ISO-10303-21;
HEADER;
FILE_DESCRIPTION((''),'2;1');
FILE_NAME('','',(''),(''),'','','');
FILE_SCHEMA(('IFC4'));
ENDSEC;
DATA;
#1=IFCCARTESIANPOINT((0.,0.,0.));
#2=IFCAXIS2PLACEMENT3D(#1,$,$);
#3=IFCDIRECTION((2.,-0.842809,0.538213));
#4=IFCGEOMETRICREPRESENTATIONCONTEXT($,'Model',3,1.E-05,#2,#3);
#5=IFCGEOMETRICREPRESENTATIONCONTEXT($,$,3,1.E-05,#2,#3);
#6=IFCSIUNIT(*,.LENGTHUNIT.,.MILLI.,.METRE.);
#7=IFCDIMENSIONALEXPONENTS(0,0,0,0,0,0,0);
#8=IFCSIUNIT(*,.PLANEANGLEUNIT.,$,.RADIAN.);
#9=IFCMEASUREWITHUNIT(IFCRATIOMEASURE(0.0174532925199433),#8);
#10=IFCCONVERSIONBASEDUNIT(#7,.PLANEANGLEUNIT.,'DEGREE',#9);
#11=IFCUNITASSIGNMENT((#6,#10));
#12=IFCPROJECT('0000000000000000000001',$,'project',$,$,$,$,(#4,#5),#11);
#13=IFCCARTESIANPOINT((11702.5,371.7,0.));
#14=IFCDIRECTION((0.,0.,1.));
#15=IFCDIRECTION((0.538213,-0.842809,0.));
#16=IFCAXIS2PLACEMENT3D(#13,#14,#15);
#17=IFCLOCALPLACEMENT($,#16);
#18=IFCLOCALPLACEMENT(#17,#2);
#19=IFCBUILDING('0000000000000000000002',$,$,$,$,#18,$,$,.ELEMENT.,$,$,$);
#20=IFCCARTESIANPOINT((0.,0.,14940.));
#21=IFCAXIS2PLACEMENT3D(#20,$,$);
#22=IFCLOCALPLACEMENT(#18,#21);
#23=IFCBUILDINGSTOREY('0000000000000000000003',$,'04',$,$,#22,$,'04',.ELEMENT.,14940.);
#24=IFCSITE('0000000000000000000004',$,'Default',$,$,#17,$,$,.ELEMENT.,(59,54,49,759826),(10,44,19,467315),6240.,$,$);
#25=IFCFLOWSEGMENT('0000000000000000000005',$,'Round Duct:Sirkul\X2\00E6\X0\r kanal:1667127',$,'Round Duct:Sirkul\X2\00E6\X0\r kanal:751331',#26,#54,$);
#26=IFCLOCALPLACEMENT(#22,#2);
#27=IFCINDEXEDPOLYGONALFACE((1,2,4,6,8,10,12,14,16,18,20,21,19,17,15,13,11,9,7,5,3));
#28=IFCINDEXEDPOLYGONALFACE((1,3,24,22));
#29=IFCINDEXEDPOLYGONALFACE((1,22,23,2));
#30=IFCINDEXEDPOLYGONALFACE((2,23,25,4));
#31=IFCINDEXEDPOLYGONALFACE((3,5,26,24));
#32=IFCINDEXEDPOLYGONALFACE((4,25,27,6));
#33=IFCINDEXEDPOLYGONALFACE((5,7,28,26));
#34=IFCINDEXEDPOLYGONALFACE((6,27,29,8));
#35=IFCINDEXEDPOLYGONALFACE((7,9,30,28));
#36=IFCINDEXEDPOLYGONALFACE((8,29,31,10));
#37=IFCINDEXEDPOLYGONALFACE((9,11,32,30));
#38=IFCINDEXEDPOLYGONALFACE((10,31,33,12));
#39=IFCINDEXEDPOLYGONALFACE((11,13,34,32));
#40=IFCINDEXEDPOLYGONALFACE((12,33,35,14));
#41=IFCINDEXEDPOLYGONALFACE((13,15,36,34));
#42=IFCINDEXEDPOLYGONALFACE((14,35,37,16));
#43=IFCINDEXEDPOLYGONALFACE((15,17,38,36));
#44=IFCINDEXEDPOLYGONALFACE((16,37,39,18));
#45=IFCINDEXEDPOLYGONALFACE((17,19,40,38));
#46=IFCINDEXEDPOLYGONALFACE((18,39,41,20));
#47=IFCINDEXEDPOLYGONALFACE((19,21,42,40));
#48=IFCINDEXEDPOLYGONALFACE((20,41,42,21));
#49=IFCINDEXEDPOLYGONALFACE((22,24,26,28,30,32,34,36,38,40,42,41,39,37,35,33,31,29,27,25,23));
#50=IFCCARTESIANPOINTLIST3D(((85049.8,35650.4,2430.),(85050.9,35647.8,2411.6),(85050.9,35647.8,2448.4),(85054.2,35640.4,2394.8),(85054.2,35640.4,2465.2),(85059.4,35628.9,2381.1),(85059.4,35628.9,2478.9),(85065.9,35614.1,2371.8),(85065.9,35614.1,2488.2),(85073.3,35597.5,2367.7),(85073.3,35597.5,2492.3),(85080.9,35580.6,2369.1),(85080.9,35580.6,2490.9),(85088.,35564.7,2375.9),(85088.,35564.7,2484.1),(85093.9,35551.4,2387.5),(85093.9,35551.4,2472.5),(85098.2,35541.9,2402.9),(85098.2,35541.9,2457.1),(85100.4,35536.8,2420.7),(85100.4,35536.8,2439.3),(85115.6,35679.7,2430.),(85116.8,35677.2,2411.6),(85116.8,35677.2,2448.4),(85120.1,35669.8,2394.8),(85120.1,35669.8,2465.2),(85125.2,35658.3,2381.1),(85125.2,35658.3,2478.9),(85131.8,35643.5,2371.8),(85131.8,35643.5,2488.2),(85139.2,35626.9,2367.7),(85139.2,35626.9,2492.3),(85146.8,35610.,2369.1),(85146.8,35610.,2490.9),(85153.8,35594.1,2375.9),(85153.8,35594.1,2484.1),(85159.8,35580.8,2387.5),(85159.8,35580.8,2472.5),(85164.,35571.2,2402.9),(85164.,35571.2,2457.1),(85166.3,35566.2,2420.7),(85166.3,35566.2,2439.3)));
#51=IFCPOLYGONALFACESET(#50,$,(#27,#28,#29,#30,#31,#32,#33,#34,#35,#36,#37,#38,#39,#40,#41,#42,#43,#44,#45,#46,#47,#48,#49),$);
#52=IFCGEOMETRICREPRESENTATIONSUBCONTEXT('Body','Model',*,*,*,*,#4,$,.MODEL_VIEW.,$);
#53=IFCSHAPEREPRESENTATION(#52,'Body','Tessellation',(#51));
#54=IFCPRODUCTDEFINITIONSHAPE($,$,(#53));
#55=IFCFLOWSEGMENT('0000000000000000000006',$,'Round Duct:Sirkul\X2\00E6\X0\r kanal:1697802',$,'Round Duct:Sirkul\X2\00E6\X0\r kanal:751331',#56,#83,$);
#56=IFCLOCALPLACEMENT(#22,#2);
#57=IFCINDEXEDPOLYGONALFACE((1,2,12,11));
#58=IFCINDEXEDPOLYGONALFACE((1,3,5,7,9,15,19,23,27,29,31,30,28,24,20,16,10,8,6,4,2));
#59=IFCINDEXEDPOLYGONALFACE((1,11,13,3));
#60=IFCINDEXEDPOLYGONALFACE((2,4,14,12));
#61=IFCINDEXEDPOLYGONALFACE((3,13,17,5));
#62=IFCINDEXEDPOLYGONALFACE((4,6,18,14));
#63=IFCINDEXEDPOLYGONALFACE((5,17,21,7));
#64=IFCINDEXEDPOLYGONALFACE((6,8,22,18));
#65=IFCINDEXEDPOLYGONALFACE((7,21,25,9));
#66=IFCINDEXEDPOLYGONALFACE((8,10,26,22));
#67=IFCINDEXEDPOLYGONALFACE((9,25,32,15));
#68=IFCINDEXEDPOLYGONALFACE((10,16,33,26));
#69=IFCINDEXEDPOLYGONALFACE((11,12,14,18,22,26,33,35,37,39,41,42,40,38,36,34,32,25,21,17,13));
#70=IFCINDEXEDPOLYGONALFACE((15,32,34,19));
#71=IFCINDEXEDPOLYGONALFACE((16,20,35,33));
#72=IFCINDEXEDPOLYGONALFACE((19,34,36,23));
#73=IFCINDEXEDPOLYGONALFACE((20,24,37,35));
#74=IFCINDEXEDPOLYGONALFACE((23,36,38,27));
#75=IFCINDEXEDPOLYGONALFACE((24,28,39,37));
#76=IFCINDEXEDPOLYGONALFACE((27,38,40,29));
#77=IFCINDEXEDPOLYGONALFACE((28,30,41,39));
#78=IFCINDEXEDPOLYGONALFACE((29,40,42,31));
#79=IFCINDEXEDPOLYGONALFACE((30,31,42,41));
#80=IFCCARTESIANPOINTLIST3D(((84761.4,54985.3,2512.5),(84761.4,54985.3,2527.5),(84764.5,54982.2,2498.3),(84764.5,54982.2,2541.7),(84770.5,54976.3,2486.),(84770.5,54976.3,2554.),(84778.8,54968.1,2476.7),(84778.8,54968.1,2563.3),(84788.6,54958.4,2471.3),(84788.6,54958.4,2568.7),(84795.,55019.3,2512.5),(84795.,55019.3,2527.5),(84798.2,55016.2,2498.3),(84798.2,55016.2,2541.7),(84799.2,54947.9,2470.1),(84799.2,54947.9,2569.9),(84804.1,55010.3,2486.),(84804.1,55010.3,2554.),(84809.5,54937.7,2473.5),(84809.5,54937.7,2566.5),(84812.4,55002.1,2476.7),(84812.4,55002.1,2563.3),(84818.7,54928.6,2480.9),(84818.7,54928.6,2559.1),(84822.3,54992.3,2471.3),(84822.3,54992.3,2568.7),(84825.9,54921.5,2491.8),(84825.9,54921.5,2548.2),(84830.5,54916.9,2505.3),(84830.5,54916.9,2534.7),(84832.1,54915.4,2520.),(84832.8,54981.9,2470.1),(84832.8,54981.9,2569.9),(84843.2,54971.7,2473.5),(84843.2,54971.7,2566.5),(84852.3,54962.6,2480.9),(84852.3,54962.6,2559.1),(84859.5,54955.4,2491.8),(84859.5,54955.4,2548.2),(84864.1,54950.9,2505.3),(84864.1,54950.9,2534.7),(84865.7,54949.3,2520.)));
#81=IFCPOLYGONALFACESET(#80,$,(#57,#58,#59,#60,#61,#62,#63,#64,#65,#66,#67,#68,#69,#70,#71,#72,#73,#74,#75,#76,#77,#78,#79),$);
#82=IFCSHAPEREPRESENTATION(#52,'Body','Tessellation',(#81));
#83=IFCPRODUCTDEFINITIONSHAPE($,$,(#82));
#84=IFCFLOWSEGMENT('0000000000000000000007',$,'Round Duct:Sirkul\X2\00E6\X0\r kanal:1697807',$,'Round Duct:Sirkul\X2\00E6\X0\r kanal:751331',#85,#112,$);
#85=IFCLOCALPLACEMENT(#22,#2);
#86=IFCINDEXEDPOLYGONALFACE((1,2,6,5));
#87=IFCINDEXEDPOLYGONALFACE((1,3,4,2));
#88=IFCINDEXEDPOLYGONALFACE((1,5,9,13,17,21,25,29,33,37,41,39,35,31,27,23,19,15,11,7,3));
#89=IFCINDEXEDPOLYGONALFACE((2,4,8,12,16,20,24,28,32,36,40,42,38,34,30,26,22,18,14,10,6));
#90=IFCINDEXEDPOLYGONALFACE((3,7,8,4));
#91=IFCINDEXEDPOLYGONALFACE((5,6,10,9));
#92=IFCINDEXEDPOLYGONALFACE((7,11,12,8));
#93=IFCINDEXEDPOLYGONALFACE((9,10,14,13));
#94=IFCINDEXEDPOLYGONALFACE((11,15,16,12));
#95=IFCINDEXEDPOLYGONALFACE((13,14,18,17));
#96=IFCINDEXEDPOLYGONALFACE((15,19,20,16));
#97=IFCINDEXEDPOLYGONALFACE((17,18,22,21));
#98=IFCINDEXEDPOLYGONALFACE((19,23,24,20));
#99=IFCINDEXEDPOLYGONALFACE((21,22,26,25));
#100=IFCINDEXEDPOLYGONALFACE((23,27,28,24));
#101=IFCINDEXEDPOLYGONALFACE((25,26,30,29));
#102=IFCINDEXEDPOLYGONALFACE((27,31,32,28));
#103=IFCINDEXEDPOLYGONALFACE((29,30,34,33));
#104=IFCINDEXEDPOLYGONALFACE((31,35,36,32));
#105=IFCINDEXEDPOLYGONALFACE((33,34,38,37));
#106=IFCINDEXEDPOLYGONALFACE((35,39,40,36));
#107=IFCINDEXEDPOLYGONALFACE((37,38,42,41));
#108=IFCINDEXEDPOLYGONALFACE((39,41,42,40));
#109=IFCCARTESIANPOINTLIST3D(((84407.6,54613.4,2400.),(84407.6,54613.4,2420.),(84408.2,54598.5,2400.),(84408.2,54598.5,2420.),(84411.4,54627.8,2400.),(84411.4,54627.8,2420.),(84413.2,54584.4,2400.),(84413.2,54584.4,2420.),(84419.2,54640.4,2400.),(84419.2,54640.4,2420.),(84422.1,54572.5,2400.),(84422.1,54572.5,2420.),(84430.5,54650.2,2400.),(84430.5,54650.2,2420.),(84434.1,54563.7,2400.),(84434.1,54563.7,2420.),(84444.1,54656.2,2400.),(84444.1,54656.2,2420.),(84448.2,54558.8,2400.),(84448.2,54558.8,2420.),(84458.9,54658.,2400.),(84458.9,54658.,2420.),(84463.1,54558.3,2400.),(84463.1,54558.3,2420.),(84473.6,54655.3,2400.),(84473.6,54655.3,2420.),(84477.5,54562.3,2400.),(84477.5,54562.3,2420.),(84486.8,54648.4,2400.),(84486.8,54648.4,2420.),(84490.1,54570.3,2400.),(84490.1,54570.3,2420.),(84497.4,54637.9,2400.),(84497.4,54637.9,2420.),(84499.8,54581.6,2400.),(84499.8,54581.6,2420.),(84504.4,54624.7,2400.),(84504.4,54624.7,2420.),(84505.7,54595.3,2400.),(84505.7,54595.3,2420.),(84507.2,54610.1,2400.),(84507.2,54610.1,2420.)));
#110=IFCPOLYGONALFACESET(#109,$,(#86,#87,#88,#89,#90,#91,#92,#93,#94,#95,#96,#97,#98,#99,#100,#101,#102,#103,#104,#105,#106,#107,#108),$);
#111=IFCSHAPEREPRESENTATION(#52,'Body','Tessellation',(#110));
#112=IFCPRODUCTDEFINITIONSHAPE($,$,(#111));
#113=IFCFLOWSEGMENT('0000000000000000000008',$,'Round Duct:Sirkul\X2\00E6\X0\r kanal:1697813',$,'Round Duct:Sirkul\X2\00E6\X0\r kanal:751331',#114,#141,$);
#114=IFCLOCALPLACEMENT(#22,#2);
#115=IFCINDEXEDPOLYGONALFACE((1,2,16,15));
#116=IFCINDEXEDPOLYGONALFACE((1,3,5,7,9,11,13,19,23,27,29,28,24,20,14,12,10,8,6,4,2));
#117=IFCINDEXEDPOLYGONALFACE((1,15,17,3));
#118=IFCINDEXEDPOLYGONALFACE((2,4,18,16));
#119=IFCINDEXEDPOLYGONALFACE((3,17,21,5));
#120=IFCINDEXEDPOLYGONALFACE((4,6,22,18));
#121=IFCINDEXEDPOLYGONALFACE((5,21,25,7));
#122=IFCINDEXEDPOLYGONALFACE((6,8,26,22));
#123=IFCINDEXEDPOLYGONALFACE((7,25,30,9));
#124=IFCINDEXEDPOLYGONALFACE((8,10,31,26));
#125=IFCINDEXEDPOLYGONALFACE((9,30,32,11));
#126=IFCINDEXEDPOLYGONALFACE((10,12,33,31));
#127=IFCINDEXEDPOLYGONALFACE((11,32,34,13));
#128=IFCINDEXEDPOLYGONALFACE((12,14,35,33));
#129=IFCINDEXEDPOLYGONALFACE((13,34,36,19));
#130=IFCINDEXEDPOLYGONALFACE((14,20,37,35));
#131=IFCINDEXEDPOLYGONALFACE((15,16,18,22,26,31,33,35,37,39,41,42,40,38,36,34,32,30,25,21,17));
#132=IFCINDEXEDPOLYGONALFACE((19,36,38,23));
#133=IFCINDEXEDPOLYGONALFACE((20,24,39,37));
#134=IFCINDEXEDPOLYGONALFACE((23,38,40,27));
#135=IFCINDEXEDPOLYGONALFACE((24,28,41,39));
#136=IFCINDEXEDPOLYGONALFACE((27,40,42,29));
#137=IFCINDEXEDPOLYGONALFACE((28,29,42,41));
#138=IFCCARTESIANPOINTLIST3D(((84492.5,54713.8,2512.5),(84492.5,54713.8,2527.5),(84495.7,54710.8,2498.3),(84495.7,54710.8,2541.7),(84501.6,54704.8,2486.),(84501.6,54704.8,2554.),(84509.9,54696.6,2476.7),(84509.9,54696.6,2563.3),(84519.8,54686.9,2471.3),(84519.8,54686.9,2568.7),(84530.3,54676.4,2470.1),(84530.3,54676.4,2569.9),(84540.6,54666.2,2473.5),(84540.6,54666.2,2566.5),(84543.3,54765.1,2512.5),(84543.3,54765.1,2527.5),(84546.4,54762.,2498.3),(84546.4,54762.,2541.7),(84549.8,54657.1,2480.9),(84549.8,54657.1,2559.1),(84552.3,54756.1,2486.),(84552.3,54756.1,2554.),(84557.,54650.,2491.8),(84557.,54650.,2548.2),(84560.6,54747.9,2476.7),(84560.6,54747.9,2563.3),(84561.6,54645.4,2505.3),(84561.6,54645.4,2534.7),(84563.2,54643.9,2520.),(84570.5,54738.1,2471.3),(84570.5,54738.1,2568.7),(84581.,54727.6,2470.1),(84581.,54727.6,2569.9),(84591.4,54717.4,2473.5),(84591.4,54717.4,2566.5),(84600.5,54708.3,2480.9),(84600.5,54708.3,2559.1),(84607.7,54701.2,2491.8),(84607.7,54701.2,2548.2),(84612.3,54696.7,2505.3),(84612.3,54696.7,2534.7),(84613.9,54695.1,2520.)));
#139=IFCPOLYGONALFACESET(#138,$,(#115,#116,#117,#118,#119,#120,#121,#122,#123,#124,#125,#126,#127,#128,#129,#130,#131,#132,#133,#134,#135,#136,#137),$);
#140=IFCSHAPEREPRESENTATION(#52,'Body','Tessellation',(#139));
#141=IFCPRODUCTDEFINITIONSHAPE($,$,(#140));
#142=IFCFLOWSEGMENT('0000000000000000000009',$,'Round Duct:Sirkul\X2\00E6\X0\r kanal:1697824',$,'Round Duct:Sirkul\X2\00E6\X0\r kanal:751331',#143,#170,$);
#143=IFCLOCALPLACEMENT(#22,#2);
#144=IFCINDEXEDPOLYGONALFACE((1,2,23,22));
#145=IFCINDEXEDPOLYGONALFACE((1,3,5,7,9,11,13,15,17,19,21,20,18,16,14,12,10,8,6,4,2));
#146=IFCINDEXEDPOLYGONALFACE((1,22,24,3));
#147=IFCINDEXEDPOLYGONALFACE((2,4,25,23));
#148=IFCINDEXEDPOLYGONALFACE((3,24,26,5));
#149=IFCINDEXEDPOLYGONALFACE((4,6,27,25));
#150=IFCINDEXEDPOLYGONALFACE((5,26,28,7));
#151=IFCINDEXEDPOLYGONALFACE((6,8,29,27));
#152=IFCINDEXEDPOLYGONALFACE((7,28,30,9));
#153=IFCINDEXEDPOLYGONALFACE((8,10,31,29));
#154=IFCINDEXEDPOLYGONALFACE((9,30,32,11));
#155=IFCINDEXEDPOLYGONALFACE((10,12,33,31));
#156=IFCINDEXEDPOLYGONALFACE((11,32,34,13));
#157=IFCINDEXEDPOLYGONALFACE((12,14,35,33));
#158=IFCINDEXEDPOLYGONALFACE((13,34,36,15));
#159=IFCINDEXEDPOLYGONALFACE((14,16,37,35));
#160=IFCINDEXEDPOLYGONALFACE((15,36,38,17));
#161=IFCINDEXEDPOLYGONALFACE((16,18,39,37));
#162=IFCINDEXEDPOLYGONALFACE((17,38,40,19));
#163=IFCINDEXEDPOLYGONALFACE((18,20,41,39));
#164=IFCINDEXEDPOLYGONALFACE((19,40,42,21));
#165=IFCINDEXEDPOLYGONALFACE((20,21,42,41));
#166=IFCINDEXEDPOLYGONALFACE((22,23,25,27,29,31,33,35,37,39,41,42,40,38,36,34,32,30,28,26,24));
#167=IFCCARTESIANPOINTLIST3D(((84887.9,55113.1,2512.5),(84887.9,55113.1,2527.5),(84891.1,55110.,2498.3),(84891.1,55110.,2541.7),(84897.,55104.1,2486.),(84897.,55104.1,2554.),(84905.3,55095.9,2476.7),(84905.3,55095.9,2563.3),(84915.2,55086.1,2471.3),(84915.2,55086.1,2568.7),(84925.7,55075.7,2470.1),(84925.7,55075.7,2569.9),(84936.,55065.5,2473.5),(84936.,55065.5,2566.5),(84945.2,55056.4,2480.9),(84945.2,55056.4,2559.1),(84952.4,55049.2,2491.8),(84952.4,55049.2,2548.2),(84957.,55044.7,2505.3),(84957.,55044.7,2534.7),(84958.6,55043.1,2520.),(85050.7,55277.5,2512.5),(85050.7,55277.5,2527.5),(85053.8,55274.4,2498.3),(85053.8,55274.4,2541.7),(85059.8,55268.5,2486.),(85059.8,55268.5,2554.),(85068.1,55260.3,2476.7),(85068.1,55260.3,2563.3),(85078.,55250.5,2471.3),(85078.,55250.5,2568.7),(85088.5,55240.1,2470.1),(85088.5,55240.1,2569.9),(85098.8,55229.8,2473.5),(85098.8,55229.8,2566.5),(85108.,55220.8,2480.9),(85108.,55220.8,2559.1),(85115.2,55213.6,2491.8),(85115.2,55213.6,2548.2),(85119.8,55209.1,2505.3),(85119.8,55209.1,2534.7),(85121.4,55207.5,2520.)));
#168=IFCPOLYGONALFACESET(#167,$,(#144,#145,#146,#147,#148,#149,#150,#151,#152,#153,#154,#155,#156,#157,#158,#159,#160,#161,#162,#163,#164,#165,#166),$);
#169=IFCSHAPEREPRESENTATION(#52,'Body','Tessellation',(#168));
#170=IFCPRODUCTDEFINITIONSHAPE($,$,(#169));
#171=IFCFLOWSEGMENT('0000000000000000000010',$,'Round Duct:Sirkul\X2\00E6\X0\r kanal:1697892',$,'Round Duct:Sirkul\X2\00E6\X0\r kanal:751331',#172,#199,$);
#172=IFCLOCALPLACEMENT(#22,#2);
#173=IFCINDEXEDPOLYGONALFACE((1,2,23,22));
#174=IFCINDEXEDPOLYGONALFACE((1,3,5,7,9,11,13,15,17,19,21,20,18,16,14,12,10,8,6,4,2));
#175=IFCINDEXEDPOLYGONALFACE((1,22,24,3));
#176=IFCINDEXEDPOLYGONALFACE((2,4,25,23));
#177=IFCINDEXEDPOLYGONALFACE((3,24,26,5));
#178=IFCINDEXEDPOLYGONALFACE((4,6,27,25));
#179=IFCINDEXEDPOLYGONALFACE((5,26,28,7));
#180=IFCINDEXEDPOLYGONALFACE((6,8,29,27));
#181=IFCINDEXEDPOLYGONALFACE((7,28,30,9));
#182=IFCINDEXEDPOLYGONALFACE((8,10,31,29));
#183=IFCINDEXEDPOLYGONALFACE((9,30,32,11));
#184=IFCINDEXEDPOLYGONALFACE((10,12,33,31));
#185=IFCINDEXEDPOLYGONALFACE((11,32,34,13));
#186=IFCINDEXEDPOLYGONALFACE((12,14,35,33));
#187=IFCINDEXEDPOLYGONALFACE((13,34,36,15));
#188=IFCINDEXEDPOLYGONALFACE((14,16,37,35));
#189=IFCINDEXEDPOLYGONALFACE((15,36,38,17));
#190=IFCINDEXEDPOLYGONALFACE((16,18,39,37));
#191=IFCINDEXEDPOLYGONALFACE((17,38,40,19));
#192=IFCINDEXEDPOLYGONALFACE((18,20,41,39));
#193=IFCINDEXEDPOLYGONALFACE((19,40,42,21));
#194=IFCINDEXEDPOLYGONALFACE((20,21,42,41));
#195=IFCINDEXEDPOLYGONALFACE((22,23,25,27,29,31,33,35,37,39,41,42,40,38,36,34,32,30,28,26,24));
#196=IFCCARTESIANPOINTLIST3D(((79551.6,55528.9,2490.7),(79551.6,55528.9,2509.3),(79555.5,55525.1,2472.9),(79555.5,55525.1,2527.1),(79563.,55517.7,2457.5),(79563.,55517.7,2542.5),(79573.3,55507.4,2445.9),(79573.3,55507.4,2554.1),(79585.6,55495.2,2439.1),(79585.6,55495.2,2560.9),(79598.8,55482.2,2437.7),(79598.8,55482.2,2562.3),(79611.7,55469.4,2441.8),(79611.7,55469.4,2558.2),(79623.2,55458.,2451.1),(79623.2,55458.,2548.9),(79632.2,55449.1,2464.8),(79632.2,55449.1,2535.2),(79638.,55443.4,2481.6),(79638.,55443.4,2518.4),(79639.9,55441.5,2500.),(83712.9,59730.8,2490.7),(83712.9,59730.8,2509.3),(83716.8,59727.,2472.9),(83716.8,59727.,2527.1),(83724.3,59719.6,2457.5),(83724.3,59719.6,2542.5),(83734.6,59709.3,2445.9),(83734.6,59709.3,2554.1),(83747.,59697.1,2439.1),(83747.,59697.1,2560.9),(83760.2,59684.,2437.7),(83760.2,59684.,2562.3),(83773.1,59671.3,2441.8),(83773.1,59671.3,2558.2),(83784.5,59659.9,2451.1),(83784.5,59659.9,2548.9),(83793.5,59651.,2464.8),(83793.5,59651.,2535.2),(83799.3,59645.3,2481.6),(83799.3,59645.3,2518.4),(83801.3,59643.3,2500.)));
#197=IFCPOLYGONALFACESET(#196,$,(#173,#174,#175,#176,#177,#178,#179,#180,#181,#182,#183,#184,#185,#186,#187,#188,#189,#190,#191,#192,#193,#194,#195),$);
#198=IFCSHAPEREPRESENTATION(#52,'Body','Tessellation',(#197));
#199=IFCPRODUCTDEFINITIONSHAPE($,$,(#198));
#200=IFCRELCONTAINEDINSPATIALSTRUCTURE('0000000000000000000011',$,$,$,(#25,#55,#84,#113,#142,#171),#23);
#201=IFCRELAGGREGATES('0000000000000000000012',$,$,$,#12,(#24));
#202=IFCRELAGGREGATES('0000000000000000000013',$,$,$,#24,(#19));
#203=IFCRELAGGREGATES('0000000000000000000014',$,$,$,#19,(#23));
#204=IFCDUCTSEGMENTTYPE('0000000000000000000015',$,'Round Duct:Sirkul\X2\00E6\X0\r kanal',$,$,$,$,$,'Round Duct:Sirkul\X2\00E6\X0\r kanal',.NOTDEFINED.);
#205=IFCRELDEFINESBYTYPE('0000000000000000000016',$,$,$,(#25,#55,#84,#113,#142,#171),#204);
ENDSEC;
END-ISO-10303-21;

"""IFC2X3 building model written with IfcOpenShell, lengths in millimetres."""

from ifc_helpers import new_model, entity, si_unit, converted_unit, direction, frame, frame_2d, origin, origin_2d_with_axis, place, context, subcontext, project, spatial, circle, extrude, type_object, element, save


model = new_model("IFC2X3")

# Units and contexts
model_context = context("Model", 3, precision=1e-05, world=origin(), true_north=direction((2.0, -0.842809, 0.538213)))
context_of_model = context(None, 3, precision=1e-05, world=origin(), true_north=direction((2.0, -0.842809, 0.538213)))
body_context = subcontext(model_context, "Body", "Model", "MODEL_VIEW")
ifc_project = project(units=[si_unit("LENGTHUNIT", "METRE", prefix="MILLI"), converted_unit("PLANEANGLEUNIT", "DEGREE", entity("IfcRatioMeasure", 0.0174532925199433), si_unit("PLANEANGLEUNIT", "RADIAN"), dimensions=[0, 0, 0, 0, 0, 0, 0])], contexts=[model_context, context_of_model])

# Site, building, storey
site_placement = place(None, frame((11702.5, 371.7, 0.0), z_axis=(0.0, 0.0, 1.0), x_axis=(0.538213, -0.842809, 0.0)))
site = spatial("IfcSite", under=ifc_project, at=site_placement, Name="Default", CompositionType="ELEMENT", RefLatitude=(59, 54, 49, 759826), RefLongitude=(10, 44, 19, 467315), RefElevation=6240.0)
building_placement = place(site_placement, origin())
building = spatial("IfcBuilding", under=site, at=building_placement, CompositionType="ELEMENT")
storey_placement = place(building_placement, frame((0.0, 0.0, 14940.0)))
storey = spatial("IfcBuildingStorey", under=building, at=storey_placement, Name="04", LongName="04", CompositionType="ELEMENT", Elevation=14940.0)

# Flow segments
duct_segment_type = type_object("IfcDuctSegmentType", Name="Round Duct:Sirkulær kanal", ElementType="Round Duct:Sirkulær kanal", PredefinedType="NOTDEFINED")
flow_segment_1_placement = place(storey_placement, origin())
element("IfcFlowSegment", 1, at=flow_segment_1_placement, inside=storey, type_object=duct_segment_type, Name="Round Duct:Sirkulær kanal:1667127", ObjectType="Round Duct:Sirkulær kanal:751331", context=body_context, shape_type="SweptSolid", body=[
    extrude(circle(Radius=62.5, at=origin_2d_with_axis()), frame((85075.2, 35593.3, 2430.0), z_axis=(0.913283, 0.407325, 0.0), x_axis=(-0.407325, 0.913283, 0.0)), (0.0, 0.0, 1.0), 72.1),
])
flow_segment_2_placement = place(storey_placement, origin())
element("IfcFlowSegment", 2, at=flow_segment_2_placement, inside=storey, type_object=duct_segment_type, Name="Round Duct:Sirkulær kanal:1697802", ObjectType="Round Duct:Sirkulær kanal:751331", context=body_context, shape_type="SweptSolid", body=[
    extrude(circle(Radius=50.0, at=origin_2d_with_axis()), frame((84796.5, 54950.5, 2520.0), z_axis=(0.703669, 0.710528, 0.0), x_axis=(0.710528, -0.703669, 0.0)), (0.0, 0.0, 1.0), 47.8),
])
flow_segment_3_placement = place(storey_placement, origin())
element("IfcFlowSegment", 3, at=flow_segment_3_placement, inside=storey, type_object=duct_segment_type, Name="Round Duct:Sirkulær kanal:1697807", ObjectType="Round Duct:Sirkulær kanal:751331", context=body_context, shape_type="SweptSolid", body=[
    extrude(circle(Radius=50.0, at=frame_2d((0.0, 0.0), x_axis=(1.0, 0.0))), frame((84457.3, 54608.0, 2400.0), z_axis=(0.0, 0.0, 1.0), x_axis=(-0.703669, -0.710528, 0.0)), (0.0, 0.0, 1.0), 20.0),
])
flow_segment_4_placement = place(storey_placement, origin())
element("IfcFlowSegment", 4, at=flow_segment_4_placement, inside=storey, type_object=duct_segment_type, Name="Round Duct:Sirkulær kanal:1697813", ObjectType="Round Duct:Sirkulær kanal:751331", context=body_context, shape_type="SweptSolid", body=[
    extrude(circle(Radius=50.0, at=origin_2d_with_axis()), frame((84527.7, 54679.1, 2520.0), z_axis=(0.703669, 0.710528, 0.0), x_axis=(0.710528, -0.703669, 0.0)), (0.0, 0.0, 1.0), 72.1),
])
flow_segment_5_placement = place(storey_placement, origin())
element("IfcFlowSegment", 5, at=flow_segment_5_placement, inside=storey, type_object=duct_segment_type, Name="Round Duct:Sirkulær kanal:1697824", ObjectType="Round Duct:Sirkulær kanal:751331", context=body_context, shape_type="SweptSolid", body=[
    extrude(circle(Radius=50.0, at=origin_2d_with_axis()), frame((84923.1, 55078.3, 2520.0), z_axis=(0.703669, 0.710528, 0.0), x_axis=(0.710528, -0.703669, 0.0)), (0.0, 0.0, 1.0), 231.4),
])
flow_segment_6_placement = place(storey_placement, origin())
element("IfcFlowSegment", 6, at=flow_segment_6_placement, inside=storey, type_object=duct_segment_type, Name="Round Duct:Sirkulær kanal:1697892", ObjectType="Round Duct:Sirkulær kanal:751331", context=body_context, shape_type="SweptSolid", body=[
    extrude(circle(Radius=62.5, at=origin_2d_with_axis()), frame((79595.5, 55485.4, 2500.0), z_axis=(0.703669, 0.710528, 0.0), x_axis=(0.710528, -0.703669, 0.0)), (0.0, 0.0, 1.0), 5913.8),
])

save(model, "model.ifc")
